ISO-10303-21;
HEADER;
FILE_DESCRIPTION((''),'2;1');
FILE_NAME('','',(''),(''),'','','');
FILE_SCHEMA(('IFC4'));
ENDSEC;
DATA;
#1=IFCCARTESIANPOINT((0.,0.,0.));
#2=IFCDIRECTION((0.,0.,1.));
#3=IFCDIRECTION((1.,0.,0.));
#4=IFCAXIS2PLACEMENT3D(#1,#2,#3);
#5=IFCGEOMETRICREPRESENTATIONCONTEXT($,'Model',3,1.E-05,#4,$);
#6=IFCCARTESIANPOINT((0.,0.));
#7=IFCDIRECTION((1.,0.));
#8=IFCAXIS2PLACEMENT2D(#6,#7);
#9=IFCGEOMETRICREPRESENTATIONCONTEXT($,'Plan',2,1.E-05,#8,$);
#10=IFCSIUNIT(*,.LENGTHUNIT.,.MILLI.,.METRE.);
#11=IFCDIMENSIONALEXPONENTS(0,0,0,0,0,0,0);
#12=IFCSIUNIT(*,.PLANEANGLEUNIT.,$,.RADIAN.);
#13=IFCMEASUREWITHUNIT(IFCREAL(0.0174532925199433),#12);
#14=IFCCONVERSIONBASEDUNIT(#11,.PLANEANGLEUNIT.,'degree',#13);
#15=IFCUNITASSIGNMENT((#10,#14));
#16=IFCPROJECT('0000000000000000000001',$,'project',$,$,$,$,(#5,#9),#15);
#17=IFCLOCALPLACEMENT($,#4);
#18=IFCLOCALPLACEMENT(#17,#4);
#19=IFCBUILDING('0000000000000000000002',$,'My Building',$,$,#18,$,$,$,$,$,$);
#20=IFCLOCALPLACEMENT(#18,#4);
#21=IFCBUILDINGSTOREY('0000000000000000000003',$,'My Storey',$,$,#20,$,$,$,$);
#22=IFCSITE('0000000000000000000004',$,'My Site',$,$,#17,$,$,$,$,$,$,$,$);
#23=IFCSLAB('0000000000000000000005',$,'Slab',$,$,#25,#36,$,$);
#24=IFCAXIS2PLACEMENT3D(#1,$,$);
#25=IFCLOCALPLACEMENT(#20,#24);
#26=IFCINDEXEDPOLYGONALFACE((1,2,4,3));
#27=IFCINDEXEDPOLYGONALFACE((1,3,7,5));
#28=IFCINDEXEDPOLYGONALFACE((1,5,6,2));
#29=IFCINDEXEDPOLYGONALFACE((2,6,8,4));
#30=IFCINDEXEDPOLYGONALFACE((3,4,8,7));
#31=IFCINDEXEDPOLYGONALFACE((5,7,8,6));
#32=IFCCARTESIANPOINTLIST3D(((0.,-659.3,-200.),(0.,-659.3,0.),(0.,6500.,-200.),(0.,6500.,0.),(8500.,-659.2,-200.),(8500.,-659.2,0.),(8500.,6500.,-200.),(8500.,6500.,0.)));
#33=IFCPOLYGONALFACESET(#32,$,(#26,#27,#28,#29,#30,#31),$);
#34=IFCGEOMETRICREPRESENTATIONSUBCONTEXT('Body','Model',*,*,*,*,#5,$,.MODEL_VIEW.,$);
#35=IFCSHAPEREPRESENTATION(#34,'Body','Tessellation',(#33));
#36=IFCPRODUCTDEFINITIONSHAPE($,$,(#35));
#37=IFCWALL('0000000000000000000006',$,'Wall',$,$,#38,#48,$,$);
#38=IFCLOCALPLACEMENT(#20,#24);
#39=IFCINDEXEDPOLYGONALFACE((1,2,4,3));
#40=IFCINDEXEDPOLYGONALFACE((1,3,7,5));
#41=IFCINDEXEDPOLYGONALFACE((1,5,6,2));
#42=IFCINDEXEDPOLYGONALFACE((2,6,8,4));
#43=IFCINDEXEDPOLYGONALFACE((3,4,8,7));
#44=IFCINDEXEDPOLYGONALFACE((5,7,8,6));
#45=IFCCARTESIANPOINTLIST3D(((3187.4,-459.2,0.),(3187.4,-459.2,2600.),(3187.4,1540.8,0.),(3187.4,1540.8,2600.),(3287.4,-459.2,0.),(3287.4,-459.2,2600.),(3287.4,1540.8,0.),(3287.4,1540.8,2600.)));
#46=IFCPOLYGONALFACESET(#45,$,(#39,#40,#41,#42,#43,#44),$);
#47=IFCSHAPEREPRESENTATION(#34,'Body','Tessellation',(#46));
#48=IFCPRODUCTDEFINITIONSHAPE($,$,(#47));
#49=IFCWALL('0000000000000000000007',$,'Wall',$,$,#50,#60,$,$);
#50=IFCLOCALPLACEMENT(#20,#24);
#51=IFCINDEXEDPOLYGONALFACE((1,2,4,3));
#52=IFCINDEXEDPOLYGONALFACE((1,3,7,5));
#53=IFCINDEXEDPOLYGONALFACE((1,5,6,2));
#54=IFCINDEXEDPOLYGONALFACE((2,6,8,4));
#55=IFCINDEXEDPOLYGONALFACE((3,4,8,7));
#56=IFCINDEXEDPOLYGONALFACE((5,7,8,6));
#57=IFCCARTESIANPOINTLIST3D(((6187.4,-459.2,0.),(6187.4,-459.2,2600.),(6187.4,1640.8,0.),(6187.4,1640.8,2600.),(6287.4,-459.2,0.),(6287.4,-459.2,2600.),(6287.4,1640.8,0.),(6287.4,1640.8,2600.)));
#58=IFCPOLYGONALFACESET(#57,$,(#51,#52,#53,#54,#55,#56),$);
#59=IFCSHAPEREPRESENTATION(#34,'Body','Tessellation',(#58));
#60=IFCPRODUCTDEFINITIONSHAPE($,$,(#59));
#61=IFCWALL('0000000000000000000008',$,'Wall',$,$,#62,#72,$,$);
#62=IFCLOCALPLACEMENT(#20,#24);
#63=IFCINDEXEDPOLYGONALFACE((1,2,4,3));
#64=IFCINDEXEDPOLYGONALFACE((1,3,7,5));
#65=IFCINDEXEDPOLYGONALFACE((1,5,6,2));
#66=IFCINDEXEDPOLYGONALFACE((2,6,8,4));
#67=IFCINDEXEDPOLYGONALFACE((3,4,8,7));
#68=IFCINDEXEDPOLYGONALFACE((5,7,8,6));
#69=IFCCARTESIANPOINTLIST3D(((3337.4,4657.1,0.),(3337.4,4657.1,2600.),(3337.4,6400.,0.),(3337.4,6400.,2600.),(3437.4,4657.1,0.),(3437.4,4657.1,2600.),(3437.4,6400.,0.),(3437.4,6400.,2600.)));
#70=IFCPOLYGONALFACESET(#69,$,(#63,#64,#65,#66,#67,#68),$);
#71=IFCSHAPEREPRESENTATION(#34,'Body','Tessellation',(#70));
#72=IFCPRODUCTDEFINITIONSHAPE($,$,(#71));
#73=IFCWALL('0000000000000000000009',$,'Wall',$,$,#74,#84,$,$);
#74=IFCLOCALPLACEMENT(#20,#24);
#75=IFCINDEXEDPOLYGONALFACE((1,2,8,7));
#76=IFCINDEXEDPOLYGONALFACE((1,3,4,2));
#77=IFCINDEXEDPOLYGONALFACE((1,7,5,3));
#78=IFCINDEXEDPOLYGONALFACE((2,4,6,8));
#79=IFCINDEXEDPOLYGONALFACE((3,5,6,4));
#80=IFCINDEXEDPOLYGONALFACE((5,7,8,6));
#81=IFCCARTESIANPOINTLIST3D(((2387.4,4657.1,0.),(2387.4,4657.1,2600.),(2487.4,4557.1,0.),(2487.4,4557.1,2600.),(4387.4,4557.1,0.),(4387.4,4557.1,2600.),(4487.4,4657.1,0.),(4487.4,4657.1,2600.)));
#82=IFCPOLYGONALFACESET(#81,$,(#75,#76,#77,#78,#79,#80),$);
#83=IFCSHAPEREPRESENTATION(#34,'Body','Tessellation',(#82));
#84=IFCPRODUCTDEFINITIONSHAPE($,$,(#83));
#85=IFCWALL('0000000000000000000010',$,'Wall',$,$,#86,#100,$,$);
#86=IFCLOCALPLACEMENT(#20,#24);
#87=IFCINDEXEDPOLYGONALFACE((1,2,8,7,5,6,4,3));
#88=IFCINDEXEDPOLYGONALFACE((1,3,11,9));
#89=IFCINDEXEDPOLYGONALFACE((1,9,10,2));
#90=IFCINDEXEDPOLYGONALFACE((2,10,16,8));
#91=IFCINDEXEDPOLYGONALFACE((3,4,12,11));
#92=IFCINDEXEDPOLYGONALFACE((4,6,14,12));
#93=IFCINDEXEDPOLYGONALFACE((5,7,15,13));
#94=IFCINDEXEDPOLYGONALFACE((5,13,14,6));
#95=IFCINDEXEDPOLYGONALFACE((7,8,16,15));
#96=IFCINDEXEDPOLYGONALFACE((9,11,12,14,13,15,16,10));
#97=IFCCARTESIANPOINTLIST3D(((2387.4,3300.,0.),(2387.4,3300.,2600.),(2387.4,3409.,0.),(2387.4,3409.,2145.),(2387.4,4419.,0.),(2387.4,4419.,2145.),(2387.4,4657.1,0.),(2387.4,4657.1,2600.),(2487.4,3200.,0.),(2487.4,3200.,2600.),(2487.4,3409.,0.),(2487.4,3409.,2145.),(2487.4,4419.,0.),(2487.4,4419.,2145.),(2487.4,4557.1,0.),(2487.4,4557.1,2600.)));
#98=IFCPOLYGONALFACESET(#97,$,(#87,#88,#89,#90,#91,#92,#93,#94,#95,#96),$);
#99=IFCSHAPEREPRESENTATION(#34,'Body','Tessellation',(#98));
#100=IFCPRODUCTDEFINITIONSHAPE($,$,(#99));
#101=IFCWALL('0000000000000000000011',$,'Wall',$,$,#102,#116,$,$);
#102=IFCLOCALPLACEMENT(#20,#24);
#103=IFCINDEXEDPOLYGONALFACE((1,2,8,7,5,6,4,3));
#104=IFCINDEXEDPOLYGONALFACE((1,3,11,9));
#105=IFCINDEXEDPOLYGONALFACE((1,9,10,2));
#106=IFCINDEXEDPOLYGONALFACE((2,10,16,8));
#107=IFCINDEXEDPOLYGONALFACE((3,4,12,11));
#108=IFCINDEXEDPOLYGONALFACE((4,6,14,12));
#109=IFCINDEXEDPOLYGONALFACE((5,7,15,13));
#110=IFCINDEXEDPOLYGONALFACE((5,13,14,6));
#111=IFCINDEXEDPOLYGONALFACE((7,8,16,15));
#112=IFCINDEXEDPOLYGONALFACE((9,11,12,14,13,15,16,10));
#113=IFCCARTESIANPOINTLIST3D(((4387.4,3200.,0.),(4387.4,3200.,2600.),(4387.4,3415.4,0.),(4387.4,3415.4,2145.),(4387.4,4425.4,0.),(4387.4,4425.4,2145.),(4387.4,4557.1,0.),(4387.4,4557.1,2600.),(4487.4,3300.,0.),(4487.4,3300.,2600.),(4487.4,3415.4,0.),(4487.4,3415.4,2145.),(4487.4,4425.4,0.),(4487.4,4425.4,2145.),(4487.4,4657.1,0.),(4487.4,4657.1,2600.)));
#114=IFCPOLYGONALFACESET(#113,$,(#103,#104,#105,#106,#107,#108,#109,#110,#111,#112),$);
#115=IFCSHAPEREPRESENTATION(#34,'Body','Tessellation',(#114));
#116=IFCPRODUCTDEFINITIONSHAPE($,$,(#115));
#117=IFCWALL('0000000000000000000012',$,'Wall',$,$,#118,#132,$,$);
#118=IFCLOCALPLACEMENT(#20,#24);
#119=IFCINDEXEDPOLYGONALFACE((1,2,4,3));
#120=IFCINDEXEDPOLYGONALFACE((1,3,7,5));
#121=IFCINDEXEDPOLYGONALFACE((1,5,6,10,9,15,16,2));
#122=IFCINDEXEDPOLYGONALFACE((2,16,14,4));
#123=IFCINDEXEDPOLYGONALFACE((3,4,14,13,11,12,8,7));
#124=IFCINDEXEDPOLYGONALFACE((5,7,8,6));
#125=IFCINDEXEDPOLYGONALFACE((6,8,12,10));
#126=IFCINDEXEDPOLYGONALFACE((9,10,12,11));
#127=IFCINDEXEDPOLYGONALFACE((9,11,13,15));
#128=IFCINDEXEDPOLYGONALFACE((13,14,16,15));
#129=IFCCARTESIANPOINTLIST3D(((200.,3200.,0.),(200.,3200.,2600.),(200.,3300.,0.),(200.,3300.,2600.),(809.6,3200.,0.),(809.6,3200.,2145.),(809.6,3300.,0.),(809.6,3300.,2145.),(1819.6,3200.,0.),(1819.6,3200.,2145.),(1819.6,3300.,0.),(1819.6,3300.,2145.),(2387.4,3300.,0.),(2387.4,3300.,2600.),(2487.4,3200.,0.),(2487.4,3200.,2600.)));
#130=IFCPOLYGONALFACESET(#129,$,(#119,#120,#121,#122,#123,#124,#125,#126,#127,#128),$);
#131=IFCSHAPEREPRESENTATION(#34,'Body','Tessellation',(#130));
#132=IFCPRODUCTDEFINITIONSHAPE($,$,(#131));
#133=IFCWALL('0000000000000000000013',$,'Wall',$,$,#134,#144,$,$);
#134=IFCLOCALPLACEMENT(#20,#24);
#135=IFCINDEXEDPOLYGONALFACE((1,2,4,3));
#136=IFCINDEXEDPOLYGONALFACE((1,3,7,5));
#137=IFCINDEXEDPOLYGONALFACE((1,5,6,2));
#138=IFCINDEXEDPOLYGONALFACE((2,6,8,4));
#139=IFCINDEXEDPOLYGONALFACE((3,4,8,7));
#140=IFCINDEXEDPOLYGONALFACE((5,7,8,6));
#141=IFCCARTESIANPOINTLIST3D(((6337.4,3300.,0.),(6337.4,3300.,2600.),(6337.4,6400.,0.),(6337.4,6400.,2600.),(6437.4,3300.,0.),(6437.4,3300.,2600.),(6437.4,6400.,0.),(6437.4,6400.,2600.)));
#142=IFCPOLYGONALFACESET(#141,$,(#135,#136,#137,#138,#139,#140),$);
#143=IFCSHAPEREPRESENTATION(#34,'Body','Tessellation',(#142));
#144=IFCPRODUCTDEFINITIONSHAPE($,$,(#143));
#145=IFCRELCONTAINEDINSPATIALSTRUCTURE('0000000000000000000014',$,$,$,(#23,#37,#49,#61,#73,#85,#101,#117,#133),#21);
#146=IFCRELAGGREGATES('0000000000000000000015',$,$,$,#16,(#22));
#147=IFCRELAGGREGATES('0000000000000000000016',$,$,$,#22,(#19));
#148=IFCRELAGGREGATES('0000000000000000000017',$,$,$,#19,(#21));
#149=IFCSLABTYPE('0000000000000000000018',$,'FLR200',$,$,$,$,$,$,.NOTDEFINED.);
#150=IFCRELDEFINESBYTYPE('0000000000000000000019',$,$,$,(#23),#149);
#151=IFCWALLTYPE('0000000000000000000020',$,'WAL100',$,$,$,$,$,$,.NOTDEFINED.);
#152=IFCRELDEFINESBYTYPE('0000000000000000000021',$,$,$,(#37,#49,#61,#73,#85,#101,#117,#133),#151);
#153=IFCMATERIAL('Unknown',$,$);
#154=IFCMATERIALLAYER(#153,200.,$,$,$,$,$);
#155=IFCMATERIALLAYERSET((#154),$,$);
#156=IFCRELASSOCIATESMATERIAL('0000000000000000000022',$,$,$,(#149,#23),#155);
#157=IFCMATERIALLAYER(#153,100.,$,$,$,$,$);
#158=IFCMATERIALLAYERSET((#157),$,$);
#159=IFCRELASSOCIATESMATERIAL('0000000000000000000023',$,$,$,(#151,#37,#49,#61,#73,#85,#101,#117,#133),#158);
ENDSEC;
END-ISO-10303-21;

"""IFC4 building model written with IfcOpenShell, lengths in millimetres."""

from ifc_helpers import new_model, entity, si_unit, converted_unit, frame, origin_with_axes, origin_2d_with_axis, place, context, subcontext, project, spatial, line, indexed_curve, outline, extrude, source, transform, mapped, material, layer, layer_set, layer_usage, type_object, element, save


model = new_model("IFC4")

# Units and contexts
model_context = context("Model", 3, precision=1e-05, world=origin_with_axes())
plan_context = context("Plan", 2, precision=1e-05, world=origin_2d_with_axis())
body_context = subcontext(model_context, "Body", "Model", "MODEL_VIEW")
ifc_project = project(units=[si_unit("LENGTHUNIT", "METRE", prefix="MILLI"), converted_unit("PLANEANGLEUNIT", "degree", entity("IfcReal", 0.0174532925199433), si_unit("PLANEANGLEUNIT", "RADIAN"), dimensions=[0, 0, 0, 0, 0, 0, 0])], contexts=[model_context, plan_context])

# Site, building, storey
site_placement = place(None, origin_with_axes())
site = spatial("IfcSite", under=ifc_project, at=site_placement, Name="My Site")
building_placement = place(site_placement, origin_with_axes())
building = spatial("IfcBuilding", under=site, at=building_placement, Name="My Building")
storey_placement = place(building_placement, origin_with_axes())
storey = spatial("IfcBuildingStorey", under=building, at=storey_placement, Name="My Storey")

# Slab
ifc_material = material(Name="Unknown")
ifc_layer_1 = layer(ifc_material, 200.0)
ifc_layer_set_1 = layer_set([ifc_layer_1])
ifc_layer_usage_1 = layer_usage(ifc_layer_set_1, "AXIS3", "POSITIVE", -200.0)
slab_type = type_object("IfcSlabType", Name="FLR200", PredefinedType="NOTDEFINED", material=ifc_layer_set_1)
slab_placement = place(storey_placement, frame((0.0, -659.3, 0.0), z_axis=(0.0, 0.0, 1.0), x_axis=(1.0, 0.0, 0.0)))
element("IfcSlab", 1, at=slab_placement, inside=storey, type_object=slab_type, material=ifc_layer_usage_1, Name="Slab", context=body_context, shape_type="SweptSolid", body=[
    extrude(outline(indexed_curve([(8500.0, 0.1), (8500.0, 7159.3), (0.0, 7159.3), (0.0, 0.0), (8500.0, 0.1)])), frame((0.0, 0.0, -200.0), z_axis=(0.0, 0.0, 1.0), x_axis=(1.0, 0.0, 0.0)), (0.0, 0.0, 1.0), 200.0),
])

# Wall
ifc_layer_2 = layer(ifc_material, 100.0)
ifc_layer_set_2 = layer_set([ifc_layer_2])
ifc_layer_usage_2 = layer_usage(ifc_layer_set_2, "AXIS2", "POSITIVE", 0.0)
wall_type_1 = type_object("IfcWallType", Name="WAL100", PredefinedType="NOTDEFINED", material=ifc_layer_set_2)
wall_1_placement = place(storey_placement, frame((3287.4, -459.2, 0.0), z_axis=(0.0, 0.0, 1.0), x_axis=(0.0, 1.0, 0.0)))
element("IfcWall", 2, at=wall_1_placement, inside=storey, type_object=wall_type_1, material=ifc_layer_usage_2, Name="Wall", context=body_context, shape_type="SweptSolid", body=[
    extrude(outline(indexed_curve([(0.0, 0.0), (0.0, 100.0), (2000.0, 100.0), (2000.0, 0.0)], segments=[line(1, 2, 3, 4, 1)])), origin_with_axes(), (0.0, 0.0, 1.0), 2600.0),
])

# Shared definitions
shared_shape_1 = source(origin_with_axes(), body_context, "Body", "SweptSolid", [
    extrude(outline(indexed_curve([(0.0, 0.0), (1010.0, 0.0), (1010.0, 2145.0), (0.0, 2145.0)], segments=[line(1, 2, 3, 4, 1)])), frame((0.0, -600.0, 0.0), z_axis=(0.0, -1.0, 0.0), x_axis=(1.0, 0.0, 0.0)), (0.0, 0.0, -1.0), 1200.0),
])

# Wall
ifc_layer_usage_3 = layer_usage(ifc_layer_set_2, "AXIS2", "POSITIVE", 0.0)
wall_2_placement = place(storey_placement, frame((6287.4, -459.2, 0.0), z_axis=(0.0, 0.0, 1.0), x_axis=(0.0, 1.0, 0.0)))
element("IfcWall", 3, at=wall_2_placement, inside=storey, type_object=wall_type_1, material=ifc_layer_usage_3, Name="Wall", context=body_context, shape_type="SweptSolid", body=[
    extrude(outline(indexed_curve([(0.0, 0.0), (0.0, 100.0), (2100.0, 100.0), (2100.0, 0.0)], segments=[line(1, 2, 3, 4, 1)])), origin_with_axes(), (0.0, 0.0, 1.0), 2600.0),
])

# Walls
ifc_layer_usage_4 = layer_usage(ifc_layer_set_2, "AXIS2", "POSITIVE", 0.0)
wall_3_placement = place(storey_placement, frame((3437.4, 4657.1, 0.0), z_axis=(0.0, 0.0, 1.0), x_axis=(0.0, 1.0, 0.0)))
element("IfcWall", 4, at=wall_3_placement, inside=storey, type_object=wall_type_1, material=ifc_layer_usage_4, Name="Wall", context=body_context, shape_type="SweptSolid", body=[
    extrude(outline(indexed_curve([(0.0, 0.0), (0.0, 100.0), (1742.9, 100.0), (1742.9, 0.0)], segments=[line(1, 2, 3, 4, 1)])), origin_with_axes(), (0.0, 0.0, 1.0), 2600.0),
])
ifc_layer_usage_5 = layer_usage(ifc_layer_set_2, "AXIS2", "POSITIVE", 0.0)
wall_4_placement = place(storey_placement, frame((4387.4, 4657.1, 0.0), z_axis=(0.0, 0.0, 1.0), x_axis=(-1.0, 0.0, 0.0)))
element("IfcWall", 5, at=wall_4_placement, inside=storey, type_object=wall_type_1, material=ifc_layer_usage_5, Name="Wall", context=body_context, shape_type="SweptSolid", body=[
    extrude(outline(indexed_curve([(-100.0, 0.0), (0.0, 100.0), (1900.0, 100.0), (2000.0, 0.0)], segments=[line(1, 2, 3, 4, 1)])), origin_with_axes(), (0.0, 0.0, 1.0), 2600.0),
])

# Walls, openings
ifc_layer_usage_6 = layer_usage(ifc_layer_set_2, "AXIS2", "POSITIVE", 0.0)
wall_5_placement = place(storey_placement, frame((2387.4, 4657.1, 0.0), z_axis=(0.0, 0.0, 1.0), x_axis=(0.0, -1.0, 0.0)))
wall_5 = element("IfcWall", 6, at=wall_5_placement, inside=storey, type_object=wall_type_1, material=ifc_layer_usage_6, Name="Wall", context=body_context, shape_type="SweptSolid", body=[
    extrude(outline(indexed_curve([(0.0, 0.0), (100.0, 100.0), (1457.1, 100.0), (1357.1, 0.0)], segments=[line(1, 2, 3, 4, 1)])), origin_with_axes(), (0.0, 0.0, 1.0), 2600.0),
])
opening_1_placement = place(wall_5_placement, frame((1248.1, 100.0, 0.0), z_axis=(0.0, 0.0, 1.0), x_axis=(-1.0, 0.0, 0.0)))
element("IfcOpeningElement", 7, at=opening_1_placement, cuts=wall_5, PredefinedType="OPENING", context=body_context, shape_type="MappedRepresentation", body=[
    mapped(shared_shape_1, transform((0.0, 0.0, 0.0), x_axis=(1.0, 0.0, 0.0), y_axis=(0.0, 1.0, 0.0), z_axis=(0.0, 0.0, 1.0), scale=1.0)),
])
ifc_layer_usage_7 = layer_usage(ifc_layer_set_2, "AXIS2", "POSITIVE", 0.0)
wall_6_placement = place(storey_placement, frame((4387.4, 4657.1, 0.0), z_axis=(0.0, 0.0, 1.0), x_axis=(0.0, -1.0, 0.0)))
wall_6 = element("IfcWall", 8, at=wall_6_placement, inside=storey, type_object=wall_type_1, material=ifc_layer_usage_7, Name="Wall", context=body_context, shape_type="SweptSolid", body=[
    extrude(outline(indexed_curve([(100.0, 0.0), (0.0, 100.0), (1357.1, 100.0), (1457.1, 0.0)], segments=[line(1, 2, 3, 4, 1)])), origin_with_axes(), (0.0, 0.0, 1.0), 2600.0),
])
opening_2_placement = place(wall_6_placement, frame((231.7, 0.0, 0.0), z_axis=(0.0, 0.0, 1.0), x_axis=(1.0, 0.0, 0.0)))
element("IfcOpeningElement", 9, at=opening_2_placement, cuts=wall_6, PredefinedType="OPENING", context=body_context, shape_type="MappedRepresentation", body=[
    mapped(shared_shape_1, transform((0.0, 0.0, 0.0), x_axis=(1.0, 0.0, 0.0), y_axis=(0.0, 1.0, 0.0), z_axis=(0.0, 0.0, 1.0), scale=1.0)),
])
ifc_layer_usage_8 = layer_usage(ifc_layer_set_2, "AXIS2", "POSITIVE", 0.0)
wall_7_placement = place(storey_placement, frame((2387.4, 3300.0, 0.0), z_axis=(0.0, 0.0, 1.0), x_axis=(-1.0, 0.0, 0.0)))
wall_7 = element("IfcWall", 10, at=wall_7_placement, inside=storey, type_object=wall_type_1, material=ifc_layer_usage_8, Name="Wall", context=body_context, shape_type="SweptSolid", body=[
    extrude(outline(indexed_curve([(0.0, 0.0), (-100.0, 100.0), (2187.4, 100.0), (2187.4, 0.0)], segments=[line(1, 2, 3, 4, 1)])), origin_with_axes(), (0.0, 0.0, 1.0), 2600.0),
])
opening_3_placement = place(wall_7_placement, frame((1577.7, 100.0, 0.0), z_axis=(0.0, 0.0, 1.0), x_axis=(-1.0, 0.0, 0.0)))
element("IfcOpeningElement", 11, at=opening_3_placement, cuts=wall_7, PredefinedType="OPENING", context=body_context, shape_type="MappedRepresentation", body=[
    mapped(shared_shape_1, transform((0.0, 0.0, 0.0), x_axis=(1.0, 0.0, 0.0), y_axis=(0.0, 1.0, 0.0), z_axis=(0.0, 0.0, 1.0), scale=1.0)),
])

# Wall
ifc_layer_usage_9 = layer_usage(ifc_layer_set_2, "AXIS2", "POSITIVE", 0.0)
wall_8_placement = place(storey_placement, frame((6437.4, 3300.0, 0.0), z_axis=(0.0, 0.0, 1.0), x_axis=(0.0, 1.0, 0.0)))
element("IfcWall", 12, at=wall_8_placement, inside=storey, type_object=wall_type_1, material=ifc_layer_usage_9, Name="Wall", context=body_context, shape_type="SweptSolid", body=[
    extrude(outline(indexed_curve([(0.0, 0.0), (0.0, 100.0), (3100.0, 100.0), (3100.0, 0.0)], segments=[line(1, 2, 3, 4, 1)])), origin_with_axes(), (0.0, 0.0, 1.0), 2600.0),
])

save(model, "model.ifc")
